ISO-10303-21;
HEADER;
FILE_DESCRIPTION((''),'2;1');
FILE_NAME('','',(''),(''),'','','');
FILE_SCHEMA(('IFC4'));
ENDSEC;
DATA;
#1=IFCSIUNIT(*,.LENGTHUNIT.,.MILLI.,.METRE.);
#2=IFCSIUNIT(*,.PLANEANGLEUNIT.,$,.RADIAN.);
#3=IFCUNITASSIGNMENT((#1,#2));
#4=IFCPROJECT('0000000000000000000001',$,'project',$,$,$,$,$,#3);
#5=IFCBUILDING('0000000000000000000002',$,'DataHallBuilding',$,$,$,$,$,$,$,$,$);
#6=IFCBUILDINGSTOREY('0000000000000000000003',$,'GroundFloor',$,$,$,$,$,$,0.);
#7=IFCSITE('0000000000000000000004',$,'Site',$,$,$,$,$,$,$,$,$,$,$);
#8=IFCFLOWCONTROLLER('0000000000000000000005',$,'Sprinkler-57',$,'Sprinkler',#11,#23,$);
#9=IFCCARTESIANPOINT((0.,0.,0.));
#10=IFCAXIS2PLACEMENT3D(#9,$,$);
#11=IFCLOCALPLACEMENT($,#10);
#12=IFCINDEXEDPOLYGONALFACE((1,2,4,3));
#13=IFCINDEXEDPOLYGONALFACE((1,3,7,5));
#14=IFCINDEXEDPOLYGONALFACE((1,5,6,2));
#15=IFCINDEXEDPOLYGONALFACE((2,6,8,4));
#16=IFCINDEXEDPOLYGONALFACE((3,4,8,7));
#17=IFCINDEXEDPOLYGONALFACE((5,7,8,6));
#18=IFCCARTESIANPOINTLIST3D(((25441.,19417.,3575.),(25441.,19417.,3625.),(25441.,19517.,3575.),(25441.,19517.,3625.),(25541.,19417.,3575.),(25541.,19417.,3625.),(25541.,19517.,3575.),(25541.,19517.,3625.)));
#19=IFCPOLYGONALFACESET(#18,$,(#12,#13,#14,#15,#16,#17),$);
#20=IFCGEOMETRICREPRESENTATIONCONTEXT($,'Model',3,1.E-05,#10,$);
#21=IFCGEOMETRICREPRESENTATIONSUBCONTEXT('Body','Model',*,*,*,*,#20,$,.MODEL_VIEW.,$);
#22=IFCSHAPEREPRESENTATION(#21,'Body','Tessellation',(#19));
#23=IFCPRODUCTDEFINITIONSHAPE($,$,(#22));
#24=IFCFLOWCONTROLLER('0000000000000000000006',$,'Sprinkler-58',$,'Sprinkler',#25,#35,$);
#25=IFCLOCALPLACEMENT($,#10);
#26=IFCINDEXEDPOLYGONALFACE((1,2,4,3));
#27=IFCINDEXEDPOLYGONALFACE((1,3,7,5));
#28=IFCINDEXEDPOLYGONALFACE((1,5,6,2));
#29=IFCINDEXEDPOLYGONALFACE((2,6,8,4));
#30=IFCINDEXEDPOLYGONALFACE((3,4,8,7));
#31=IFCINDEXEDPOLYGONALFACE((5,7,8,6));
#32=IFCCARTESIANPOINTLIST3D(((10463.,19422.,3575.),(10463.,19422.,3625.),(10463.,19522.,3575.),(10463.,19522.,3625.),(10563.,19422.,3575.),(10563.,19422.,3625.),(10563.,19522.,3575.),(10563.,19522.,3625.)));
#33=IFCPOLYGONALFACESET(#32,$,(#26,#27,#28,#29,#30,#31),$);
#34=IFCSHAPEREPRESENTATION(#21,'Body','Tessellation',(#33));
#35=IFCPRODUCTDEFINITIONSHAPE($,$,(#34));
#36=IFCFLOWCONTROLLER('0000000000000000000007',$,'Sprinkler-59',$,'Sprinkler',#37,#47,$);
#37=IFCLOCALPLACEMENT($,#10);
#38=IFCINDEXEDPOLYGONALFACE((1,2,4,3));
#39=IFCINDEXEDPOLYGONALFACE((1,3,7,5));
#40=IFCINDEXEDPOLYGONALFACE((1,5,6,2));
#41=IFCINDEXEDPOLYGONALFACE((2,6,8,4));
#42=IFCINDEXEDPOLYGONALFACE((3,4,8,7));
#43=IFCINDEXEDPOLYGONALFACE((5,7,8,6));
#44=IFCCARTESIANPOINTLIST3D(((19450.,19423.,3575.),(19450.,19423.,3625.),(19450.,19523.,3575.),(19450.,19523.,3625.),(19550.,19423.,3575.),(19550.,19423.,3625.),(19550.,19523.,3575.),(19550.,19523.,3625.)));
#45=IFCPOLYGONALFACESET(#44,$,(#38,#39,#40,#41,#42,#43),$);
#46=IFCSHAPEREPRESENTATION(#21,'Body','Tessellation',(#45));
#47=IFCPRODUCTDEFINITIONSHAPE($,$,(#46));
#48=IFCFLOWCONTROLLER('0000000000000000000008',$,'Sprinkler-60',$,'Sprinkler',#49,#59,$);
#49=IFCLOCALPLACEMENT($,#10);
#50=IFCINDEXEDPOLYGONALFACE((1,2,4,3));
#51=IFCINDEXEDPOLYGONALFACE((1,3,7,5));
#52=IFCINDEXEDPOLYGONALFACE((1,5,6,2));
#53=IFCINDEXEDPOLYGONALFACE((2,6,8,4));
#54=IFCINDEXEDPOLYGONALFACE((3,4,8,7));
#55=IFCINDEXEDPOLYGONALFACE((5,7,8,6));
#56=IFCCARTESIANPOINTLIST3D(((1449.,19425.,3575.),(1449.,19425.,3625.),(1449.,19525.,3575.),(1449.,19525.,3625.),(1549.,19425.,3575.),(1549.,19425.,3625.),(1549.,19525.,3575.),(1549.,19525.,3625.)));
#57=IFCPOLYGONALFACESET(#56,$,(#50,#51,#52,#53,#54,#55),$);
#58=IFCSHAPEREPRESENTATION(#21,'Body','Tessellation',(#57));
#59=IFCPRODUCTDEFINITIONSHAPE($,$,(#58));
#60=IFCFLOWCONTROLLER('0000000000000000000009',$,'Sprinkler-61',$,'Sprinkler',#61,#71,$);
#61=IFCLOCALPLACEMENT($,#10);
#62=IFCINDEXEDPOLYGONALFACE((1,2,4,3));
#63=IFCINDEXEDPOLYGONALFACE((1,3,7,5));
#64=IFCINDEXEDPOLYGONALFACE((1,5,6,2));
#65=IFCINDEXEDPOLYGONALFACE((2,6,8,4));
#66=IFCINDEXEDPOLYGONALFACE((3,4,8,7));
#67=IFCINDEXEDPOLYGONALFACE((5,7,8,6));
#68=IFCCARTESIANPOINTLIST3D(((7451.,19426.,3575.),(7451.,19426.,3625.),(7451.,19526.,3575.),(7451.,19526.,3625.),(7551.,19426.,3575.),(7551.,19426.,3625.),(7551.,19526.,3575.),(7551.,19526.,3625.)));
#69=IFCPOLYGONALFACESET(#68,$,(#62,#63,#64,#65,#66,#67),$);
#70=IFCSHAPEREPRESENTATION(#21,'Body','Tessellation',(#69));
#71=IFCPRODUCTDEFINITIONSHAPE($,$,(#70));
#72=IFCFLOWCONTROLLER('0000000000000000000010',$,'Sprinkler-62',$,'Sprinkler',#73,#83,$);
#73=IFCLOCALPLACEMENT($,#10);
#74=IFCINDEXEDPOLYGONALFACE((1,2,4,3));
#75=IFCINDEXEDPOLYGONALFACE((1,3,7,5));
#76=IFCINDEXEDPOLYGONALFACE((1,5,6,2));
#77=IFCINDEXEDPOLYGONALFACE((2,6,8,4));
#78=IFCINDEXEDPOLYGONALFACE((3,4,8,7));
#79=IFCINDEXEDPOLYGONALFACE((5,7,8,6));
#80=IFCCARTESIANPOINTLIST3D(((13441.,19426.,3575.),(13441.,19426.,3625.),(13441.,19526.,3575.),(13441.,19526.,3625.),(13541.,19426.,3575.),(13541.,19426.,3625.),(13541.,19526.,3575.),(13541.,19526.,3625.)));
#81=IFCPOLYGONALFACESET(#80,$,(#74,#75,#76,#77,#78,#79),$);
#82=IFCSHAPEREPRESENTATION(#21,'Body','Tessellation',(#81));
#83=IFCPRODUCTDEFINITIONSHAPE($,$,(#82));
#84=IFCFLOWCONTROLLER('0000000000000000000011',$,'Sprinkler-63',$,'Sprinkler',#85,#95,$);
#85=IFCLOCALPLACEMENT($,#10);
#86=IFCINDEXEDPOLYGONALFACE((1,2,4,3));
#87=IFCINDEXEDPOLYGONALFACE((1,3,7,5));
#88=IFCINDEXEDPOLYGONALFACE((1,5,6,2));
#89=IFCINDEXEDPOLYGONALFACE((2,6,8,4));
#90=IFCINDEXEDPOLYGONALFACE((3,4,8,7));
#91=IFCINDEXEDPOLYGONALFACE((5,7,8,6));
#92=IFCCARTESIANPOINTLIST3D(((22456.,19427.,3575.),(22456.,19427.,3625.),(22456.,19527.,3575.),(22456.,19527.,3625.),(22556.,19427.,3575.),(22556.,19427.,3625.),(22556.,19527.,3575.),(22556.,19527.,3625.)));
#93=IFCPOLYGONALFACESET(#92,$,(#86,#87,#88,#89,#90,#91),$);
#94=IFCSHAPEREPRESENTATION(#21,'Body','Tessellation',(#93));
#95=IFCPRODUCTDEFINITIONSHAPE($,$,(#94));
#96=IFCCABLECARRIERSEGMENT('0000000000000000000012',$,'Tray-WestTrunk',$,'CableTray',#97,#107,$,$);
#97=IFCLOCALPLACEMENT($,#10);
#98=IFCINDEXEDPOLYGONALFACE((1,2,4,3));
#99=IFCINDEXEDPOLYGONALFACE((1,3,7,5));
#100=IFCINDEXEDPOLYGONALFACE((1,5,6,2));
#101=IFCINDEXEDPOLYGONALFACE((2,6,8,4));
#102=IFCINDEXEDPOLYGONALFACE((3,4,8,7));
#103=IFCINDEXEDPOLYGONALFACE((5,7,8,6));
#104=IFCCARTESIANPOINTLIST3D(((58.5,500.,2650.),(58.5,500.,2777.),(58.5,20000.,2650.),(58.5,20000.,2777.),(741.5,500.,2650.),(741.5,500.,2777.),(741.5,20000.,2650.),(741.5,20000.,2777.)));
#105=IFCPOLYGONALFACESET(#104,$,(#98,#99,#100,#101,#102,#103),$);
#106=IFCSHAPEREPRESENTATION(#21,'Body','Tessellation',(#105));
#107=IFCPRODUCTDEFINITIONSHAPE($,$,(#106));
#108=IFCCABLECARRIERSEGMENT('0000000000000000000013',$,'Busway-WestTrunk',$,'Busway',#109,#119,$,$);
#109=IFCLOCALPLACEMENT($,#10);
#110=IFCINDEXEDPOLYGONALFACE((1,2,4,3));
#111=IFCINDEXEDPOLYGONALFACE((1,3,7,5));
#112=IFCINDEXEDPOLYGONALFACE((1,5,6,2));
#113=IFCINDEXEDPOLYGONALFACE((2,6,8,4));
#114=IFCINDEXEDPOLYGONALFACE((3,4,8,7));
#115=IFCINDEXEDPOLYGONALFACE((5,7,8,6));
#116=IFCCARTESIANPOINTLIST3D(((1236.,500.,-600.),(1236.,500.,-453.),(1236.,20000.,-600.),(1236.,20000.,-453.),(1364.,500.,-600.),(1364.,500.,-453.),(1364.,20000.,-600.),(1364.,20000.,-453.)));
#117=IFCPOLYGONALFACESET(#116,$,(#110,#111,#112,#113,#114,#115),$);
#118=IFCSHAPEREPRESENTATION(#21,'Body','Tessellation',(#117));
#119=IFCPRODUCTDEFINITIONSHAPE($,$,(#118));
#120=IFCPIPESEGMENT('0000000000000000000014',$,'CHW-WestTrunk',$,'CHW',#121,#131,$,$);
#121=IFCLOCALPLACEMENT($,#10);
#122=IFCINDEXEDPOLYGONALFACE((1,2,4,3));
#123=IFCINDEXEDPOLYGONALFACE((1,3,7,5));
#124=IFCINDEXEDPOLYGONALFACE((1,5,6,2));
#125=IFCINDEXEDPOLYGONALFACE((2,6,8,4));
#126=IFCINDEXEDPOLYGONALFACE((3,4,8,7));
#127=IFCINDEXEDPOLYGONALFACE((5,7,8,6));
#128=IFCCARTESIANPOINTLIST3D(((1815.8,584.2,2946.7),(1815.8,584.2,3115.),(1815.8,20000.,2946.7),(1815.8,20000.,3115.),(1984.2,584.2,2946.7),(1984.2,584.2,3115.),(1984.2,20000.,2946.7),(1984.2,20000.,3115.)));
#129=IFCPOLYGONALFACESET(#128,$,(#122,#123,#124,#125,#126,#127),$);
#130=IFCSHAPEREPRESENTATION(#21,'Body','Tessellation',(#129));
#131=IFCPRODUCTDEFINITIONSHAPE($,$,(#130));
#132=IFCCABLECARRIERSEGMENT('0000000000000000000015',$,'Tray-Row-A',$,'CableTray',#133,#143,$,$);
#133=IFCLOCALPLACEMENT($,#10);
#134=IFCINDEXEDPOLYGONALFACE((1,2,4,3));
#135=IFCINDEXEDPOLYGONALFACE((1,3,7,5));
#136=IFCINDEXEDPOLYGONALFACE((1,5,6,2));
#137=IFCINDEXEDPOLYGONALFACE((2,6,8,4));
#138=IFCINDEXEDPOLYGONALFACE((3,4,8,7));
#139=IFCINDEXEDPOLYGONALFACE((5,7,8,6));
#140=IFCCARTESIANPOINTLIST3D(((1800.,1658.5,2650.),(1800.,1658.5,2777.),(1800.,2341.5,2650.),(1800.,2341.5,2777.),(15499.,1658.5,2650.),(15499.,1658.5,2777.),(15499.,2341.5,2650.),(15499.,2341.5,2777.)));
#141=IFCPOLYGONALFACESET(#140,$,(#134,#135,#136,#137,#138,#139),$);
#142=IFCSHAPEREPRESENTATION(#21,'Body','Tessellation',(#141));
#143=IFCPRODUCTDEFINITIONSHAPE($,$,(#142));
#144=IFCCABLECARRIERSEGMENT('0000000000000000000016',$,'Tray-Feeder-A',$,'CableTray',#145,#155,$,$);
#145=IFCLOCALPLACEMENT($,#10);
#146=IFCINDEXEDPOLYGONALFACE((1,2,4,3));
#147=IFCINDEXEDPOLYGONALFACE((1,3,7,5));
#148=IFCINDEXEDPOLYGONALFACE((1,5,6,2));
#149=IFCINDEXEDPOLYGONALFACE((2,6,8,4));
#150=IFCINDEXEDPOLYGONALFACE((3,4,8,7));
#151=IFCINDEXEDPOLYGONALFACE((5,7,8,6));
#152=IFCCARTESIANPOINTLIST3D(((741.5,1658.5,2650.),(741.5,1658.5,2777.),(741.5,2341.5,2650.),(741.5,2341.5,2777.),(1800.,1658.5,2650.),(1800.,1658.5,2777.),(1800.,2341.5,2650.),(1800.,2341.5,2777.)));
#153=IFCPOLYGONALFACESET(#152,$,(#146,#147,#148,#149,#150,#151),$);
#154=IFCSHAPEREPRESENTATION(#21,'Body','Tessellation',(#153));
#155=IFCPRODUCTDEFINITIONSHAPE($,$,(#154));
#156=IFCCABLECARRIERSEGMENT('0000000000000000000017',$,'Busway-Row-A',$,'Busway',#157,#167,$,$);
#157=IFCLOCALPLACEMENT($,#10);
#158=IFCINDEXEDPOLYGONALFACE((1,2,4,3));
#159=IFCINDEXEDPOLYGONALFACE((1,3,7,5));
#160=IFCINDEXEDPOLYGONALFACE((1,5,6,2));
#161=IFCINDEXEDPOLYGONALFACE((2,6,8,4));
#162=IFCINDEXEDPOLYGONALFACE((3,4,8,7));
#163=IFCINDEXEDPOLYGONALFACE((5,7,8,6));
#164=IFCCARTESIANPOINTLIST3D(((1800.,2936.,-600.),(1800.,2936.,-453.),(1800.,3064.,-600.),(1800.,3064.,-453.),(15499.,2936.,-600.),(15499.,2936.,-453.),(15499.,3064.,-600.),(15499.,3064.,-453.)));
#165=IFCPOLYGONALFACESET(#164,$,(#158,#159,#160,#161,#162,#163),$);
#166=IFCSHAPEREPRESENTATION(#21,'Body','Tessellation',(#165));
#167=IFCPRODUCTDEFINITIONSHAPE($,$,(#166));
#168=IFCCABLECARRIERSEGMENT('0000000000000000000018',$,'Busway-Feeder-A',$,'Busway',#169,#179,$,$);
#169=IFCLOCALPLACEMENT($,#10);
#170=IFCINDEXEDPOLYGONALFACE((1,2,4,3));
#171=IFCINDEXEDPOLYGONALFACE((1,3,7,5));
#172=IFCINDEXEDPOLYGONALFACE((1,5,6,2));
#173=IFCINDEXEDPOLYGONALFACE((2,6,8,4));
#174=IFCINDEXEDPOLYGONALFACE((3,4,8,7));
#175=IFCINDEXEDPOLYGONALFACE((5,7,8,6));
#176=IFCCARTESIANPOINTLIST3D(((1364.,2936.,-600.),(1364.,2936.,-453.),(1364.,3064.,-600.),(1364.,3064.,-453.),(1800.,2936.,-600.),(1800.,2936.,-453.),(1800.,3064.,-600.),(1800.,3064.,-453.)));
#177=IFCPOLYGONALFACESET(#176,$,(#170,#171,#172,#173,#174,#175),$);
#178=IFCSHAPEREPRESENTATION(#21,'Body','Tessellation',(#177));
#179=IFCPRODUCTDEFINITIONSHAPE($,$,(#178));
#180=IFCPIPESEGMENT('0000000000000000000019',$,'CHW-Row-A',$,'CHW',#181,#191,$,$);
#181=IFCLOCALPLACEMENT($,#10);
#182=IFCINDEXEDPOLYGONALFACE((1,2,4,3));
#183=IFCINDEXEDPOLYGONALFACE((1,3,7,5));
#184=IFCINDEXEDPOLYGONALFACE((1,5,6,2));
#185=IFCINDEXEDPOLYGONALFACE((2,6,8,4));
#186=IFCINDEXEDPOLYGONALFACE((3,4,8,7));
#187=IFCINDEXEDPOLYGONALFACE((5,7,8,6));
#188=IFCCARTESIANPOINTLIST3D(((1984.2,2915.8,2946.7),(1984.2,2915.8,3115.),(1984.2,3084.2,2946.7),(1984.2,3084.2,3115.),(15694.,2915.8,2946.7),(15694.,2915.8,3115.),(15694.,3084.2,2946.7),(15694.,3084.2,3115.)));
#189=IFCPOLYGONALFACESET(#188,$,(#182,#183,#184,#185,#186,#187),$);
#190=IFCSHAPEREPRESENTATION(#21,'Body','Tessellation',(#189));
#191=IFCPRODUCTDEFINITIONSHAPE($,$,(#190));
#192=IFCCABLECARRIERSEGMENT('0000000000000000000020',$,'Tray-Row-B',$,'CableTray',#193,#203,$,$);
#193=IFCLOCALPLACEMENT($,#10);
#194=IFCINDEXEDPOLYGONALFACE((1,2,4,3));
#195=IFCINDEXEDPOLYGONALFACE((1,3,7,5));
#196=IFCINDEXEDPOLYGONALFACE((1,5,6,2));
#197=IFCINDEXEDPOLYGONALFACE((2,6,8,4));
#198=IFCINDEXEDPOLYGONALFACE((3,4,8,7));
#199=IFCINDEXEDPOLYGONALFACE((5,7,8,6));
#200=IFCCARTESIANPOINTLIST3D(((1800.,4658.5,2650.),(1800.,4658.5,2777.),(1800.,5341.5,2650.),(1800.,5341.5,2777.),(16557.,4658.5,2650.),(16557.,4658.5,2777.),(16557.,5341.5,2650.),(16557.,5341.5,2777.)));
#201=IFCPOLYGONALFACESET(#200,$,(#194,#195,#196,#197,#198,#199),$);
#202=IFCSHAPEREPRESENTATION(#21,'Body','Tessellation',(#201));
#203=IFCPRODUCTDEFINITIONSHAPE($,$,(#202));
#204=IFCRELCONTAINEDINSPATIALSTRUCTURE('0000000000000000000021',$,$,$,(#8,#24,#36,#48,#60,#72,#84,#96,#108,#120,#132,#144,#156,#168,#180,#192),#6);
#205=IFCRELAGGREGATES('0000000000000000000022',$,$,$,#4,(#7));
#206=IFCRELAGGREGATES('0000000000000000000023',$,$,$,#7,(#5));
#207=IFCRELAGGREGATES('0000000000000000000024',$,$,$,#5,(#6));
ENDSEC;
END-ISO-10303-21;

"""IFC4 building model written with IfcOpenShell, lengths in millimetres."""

from ifc_helpers import new_model, si_unit, frame, origin, place, context, subcontext, project, spatial, rectangle, extrude, element, save


model = new_model("IFC4")

# Units and contexts
model_context = context("Model", 3, precision=1e-05, world=origin())
body_context = subcontext(model_context, "Body", "Model", "MODEL_VIEW")
ifc_project = project(units=[si_unit("LENGTHUNIT", "METRE", prefix="MILLI"), si_unit("PLANEANGLEUNIT", "RADIAN")])

# Site, building, storey
site = spatial("IfcSite", under=ifc_project, Name="Site")
building = spatial("IfcBuilding", under=site, Name="DataHallBuilding")
storey = spatial("IfcBuildingStorey", under=building, Name="GroundFloor", Elevation=0.0)

# Flow controllers
flow_controller_1_placement = place(None, origin())
element("IfcFlowController", 1, at=flow_controller_1_placement, inside=storey, Name="Sprinkler-57", ObjectType="Sprinkler", context=body_context, shape_type="SweptSolid", body=[
    extrude(rectangle(XDim=100.0, YDim=100.0), frame((25491.0, 19467.0, 3575.0), z_axis=(0.0, 0.0, 1.0), x_axis=(1.0, 0.0, 0.0)), (0.0, 0.0, 1.0), 50.0),
])
flow_controller_2_placement = place(None, origin())
element("IfcFlowController", 2, at=flow_controller_2_placement, inside=storey, Name="Sprinkler-58", ObjectType="Sprinkler", context=body_context, shape_type="SweptSolid", body=[
    extrude(rectangle(XDim=100.0, YDim=100.0), frame((10513.0, 19472.0, 3575.0), z_axis=(0.0, 0.0, 1.0), x_axis=(1.0, 0.0, 0.0)), (0.0, 0.0, 1.0), 50.0),
])
flow_controller_3_placement = place(None, origin())
element("IfcFlowController", 3, at=flow_controller_3_placement, inside=storey, Name="Sprinkler-59", ObjectType="Sprinkler", context=body_context, shape_type="SweptSolid", body=[
    extrude(rectangle(XDim=100.0, YDim=100.0), frame((19500.0, 19473.0, 3575.0), z_axis=(0.0, 0.0, 1.0), x_axis=(1.0, 0.0, 0.0)), (0.0, 0.0, 1.0), 50.0),
])
flow_controller_4_placement = place(None, origin())
element("IfcFlowController", 4, at=flow_controller_4_placement, inside=storey, Name="Sprinkler-60", ObjectType="Sprinkler", context=body_context, shape_type="SweptSolid", body=[
    extrude(rectangle(XDim=100.0, YDim=100.0), frame((1499.0, 19475.0, 3575.0), z_axis=(0.0, 0.0, 1.0), x_axis=(1.0, 0.0, 0.0)), (0.0, 0.0, 1.0), 50.0),
])
flow_controller_5_placement = place(None, origin())
element("IfcFlowController", 5, at=flow_controller_5_placement, inside=storey, Name="Sprinkler-61", ObjectType="Sprinkler", context=body_context, shape_type="SweptSolid", body=[
    extrude(rectangle(XDim=100.0, YDim=100.0), frame((7501.0, 19476.0, 3575.0), z_axis=(0.0, 0.0, 1.0), x_axis=(1.0, 0.0, 0.0)), (0.0, 0.0, 1.0), 50.0),
])
flow_controller_6_placement = place(None, origin())
element("IfcFlowController", 6, at=flow_controller_6_placement, inside=storey, Name="Sprinkler-62", ObjectType="Sprinkler", context=body_context, shape_type="SweptSolid", body=[
    extrude(rectangle(XDim=100.0, YDim=100.0), frame((13491.0, 19476.0, 3575.0), z_axis=(0.0, 0.0, 1.0), x_axis=(1.0, 0.0, 0.0)), (0.0, 0.0, 1.0), 50.0),
])
flow_controller_7_placement = place(None, origin())
element("IfcFlowController", 7, at=flow_controller_7_placement, inside=storey, Name="Sprinkler-63", ObjectType="Sprinkler", context=body_context, shape_type="SweptSolid", body=[
    extrude(rectangle(XDim=100.0, YDim=100.0), frame((22506.0, 19477.0, 3575.0), z_axis=(0.0, 0.0, 1.0), x_axis=(1.0, 0.0, 0.0)), (0.0, 0.0, 1.0), 50.0),
])

# Cable carrier segments
cable_carrier_segment_1_placement = place(None, origin())
element("IfcCableCarrierSegment", 8, at=cable_carrier_segment_1_placement, inside=storey, Name="Tray-WestTrunk", ObjectType="CableTray", context=body_context, shape_type="SweptSolid", body=[
    extrude(rectangle(XDim=683.0, YDim=19500.0), frame((400.0, 10250.0, 2650.0), z_axis=(0.0, 0.0, 1.0), x_axis=(1.0, 0.0, 0.0)), (0.0, 0.0, 1.0), 127.0),
])
cable_carrier_segment_2_placement = place(None, origin())
element("IfcCableCarrierSegment", 9, at=cable_carrier_segment_2_placement, inside=storey, Name="Busway-WestTrunk", ObjectType="Busway", context=body_context, shape_type="SweptSolid", body=[
    extrude(rectangle(XDim=128.0, YDim=19500.0), frame((1300.0, 10250.0, -600.0), z_axis=(0.0, 0.0, 1.0), x_axis=(1.0, 0.0, 0.0)), (0.0, 0.0, 1.0), 147.0),
])

# Pipe segment
pipe_segment_1_placement = place(None, origin())
element("IfcPipeSegment", 10, at=pipe_segment_1_placement, inside=storey, Name="CHW-WestTrunk", ObjectType="CHW", context=body_context, shape_type="SweptSolid", body=[
    extrude(rectangle(XDim=168.3, YDim=19415.8), frame((1900.0, 10292.1, 2946.7), z_axis=(0.0, 0.0, 1.0), x_axis=(1.0, 0.0, 0.0)), (0.0, 0.0, 1.0), 168.3),
])

# Cable carrier segments
cable_carrier_segment_3_placement = place(None, origin())
element("IfcCableCarrierSegment", 11, at=cable_carrier_segment_3_placement, inside=storey, Name="Tray-Row-A", ObjectType="CableTray", context=body_context, shape_type="SweptSolid", body=[
    extrude(rectangle(XDim=13699.0, YDim=683.0), frame((8649.5, 2000.0, 2650.0), z_axis=(0.0, 0.0, 1.0), x_axis=(1.0, 0.0, 0.0)), (0.0, 0.0, 1.0), 127.0),
])
cable_carrier_segment_4_placement = place(None, origin())
element("IfcCableCarrierSegment", 12, at=cable_carrier_segment_4_placement, inside=storey, Name="Tray-Feeder-A", ObjectType="CableTray", context=body_context, shape_type="SweptSolid", body=[
    extrude(rectangle(XDim=1058.5, YDim=683.0), frame((1270.8, 2000.0, 2650.0), z_axis=(0.0, 0.0, 1.0), x_axis=(1.0, 0.0, 0.0)), (0.0, 0.0, 1.0), 127.0),
])
cable_carrier_segment_5_placement = place(None, origin())
element("IfcCableCarrierSegment", 13, at=cable_carrier_segment_5_placement, inside=storey, Name="Busway-Row-A", ObjectType="Busway", context=body_context, shape_type="SweptSolid", body=[
    extrude(rectangle(XDim=13699.0, YDim=128.0), frame((8649.5, 3000.0, -600.0), z_axis=(0.0, 0.0, 1.0), x_axis=(1.0, 0.0, 0.0)), (0.0, 0.0, 1.0), 147.0),
])
cable_carrier_segment_6_placement = place(None, origin())
element("IfcCableCarrierSegment", 14, at=cable_carrier_segment_6_placement, inside=storey, Name="Busway-Feeder-A", ObjectType="Busway", context=body_context, shape_type="SweptSolid", body=[
    extrude(rectangle(XDim=436.0, YDim=128.0), frame((1582.0, 3000.0, -600.0), z_axis=(0.0, 0.0, 1.0), x_axis=(1.0, 0.0, 0.0)), (0.0, 0.0, 1.0), 147.0),
])

# Pipe segment
pipe_segment_2_placement = place(None, origin())
element("IfcPipeSegment", 15, at=pipe_segment_2_placement, inside=storey, Name="CHW-Row-A", ObjectType="CHW", context=body_context, shape_type="SweptSolid", body=[
    extrude(rectangle(XDim=13709.9, YDim=168.3), frame((8839.1, 3000.0, 2946.7), z_axis=(0.0, 0.0, 1.0), x_axis=(1.0, 0.0, 0.0)), (0.0, 0.0, 1.0), 168.3),
])

# Cable carrier segment
cable_carrier_segment_7_placement = place(None, origin())
element("IfcCableCarrierSegment", 16, at=cable_carrier_segment_7_placement, inside=storey, Name="Tray-Row-B", ObjectType="CableTray", context=body_context, shape_type="SweptSolid", body=[
    extrude(rectangle(XDim=14757.0, YDim=683.0), frame((9178.5, 5000.0, 2650.0), z_axis=(0.0, 0.0, 1.0), x_axis=(1.0, 0.0, 0.0)), (0.0, 0.0, 1.0), 127.0),
])

save(model, "model.ifc")
